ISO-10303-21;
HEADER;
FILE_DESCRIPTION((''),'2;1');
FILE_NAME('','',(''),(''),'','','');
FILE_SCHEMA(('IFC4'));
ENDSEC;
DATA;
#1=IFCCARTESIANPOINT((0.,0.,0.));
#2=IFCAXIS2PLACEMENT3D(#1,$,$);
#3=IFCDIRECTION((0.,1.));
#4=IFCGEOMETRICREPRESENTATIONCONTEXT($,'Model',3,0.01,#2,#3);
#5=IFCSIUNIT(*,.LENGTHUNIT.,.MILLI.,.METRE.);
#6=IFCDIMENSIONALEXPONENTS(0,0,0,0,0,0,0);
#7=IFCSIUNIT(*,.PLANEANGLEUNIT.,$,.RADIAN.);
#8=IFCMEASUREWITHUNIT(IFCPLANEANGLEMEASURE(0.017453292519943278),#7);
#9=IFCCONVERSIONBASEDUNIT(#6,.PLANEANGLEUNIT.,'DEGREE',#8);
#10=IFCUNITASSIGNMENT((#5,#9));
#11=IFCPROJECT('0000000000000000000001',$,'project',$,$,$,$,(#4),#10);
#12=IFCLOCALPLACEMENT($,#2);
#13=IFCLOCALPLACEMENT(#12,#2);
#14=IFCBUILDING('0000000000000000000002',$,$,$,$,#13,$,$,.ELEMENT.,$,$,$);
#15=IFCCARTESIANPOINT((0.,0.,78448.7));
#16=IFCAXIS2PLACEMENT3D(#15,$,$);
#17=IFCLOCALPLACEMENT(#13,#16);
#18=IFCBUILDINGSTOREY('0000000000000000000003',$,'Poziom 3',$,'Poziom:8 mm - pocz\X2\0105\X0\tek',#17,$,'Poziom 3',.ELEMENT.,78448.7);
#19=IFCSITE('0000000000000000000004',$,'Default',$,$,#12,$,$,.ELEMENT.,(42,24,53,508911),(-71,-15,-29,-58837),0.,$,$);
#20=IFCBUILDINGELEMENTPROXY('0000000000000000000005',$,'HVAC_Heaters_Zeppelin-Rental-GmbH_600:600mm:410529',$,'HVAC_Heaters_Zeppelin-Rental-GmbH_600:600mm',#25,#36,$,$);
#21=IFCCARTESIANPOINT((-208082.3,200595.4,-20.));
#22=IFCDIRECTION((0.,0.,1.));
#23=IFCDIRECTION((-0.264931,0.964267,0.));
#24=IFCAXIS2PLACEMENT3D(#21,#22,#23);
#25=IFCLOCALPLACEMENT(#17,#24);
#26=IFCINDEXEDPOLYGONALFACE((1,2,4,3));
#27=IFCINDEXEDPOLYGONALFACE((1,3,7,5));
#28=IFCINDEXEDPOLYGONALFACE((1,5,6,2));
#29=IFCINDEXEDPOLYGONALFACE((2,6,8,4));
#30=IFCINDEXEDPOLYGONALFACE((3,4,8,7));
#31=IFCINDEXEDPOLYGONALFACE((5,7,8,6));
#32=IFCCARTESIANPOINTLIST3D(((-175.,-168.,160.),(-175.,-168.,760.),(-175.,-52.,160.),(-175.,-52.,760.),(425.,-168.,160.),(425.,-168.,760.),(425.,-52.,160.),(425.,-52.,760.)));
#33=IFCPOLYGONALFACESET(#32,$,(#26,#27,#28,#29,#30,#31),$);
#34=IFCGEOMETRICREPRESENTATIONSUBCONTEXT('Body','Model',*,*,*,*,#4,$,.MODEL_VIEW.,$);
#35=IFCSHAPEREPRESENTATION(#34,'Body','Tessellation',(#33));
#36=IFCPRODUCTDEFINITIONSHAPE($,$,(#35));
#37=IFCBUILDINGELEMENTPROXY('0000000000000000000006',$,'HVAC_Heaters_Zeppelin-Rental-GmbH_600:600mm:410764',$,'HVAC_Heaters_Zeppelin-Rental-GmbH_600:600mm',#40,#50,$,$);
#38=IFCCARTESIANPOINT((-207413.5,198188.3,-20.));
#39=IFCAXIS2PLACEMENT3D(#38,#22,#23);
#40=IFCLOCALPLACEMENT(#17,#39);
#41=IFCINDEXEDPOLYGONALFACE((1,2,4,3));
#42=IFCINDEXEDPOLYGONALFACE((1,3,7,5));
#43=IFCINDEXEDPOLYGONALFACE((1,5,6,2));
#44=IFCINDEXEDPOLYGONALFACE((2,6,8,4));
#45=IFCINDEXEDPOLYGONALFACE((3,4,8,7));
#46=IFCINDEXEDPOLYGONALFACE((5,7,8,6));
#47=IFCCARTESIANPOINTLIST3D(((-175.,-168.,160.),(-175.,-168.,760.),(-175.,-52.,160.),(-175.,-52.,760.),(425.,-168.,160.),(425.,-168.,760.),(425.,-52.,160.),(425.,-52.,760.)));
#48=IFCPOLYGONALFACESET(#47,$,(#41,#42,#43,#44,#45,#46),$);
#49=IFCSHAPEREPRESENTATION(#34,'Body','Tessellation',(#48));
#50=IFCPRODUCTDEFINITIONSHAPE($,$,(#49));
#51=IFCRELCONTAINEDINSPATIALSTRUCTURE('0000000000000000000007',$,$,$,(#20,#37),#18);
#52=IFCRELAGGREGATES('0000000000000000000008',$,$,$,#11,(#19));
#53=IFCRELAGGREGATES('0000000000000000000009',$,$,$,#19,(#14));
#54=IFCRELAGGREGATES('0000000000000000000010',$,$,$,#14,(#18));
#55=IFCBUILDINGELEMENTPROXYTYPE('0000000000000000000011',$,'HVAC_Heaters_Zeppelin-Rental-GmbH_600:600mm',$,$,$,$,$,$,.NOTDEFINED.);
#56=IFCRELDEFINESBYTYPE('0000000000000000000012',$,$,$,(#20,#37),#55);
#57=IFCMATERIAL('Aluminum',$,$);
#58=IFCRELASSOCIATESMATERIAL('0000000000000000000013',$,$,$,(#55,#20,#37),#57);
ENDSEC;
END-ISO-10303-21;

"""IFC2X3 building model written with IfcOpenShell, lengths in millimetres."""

from ifc_helpers import new_model, entity, si_unit, converted_unit, direction, frame, frame_2d, origin, place, context, subcontext, project, spatial, rectangle, extrude, source, transform, mapped, material, type_object, type_shapes, element, save


model = new_model("IFC2X3")

# Units and contexts
model_context = context("Model", 3, precision=0.01, world=origin(), true_north=direction((0.0, 1.0)))
body_context = subcontext(model_context, "Body", "Model", "MODEL_VIEW")
ifc_project = project(units=[si_unit("LENGTHUNIT", "METRE", prefix="MILLI"), converted_unit("PLANEANGLEUNIT", "DEGREE", entity("IfcPlaneAngleMeasure", 0.017453292519943278), si_unit("PLANEANGLEUNIT", "RADIAN"), dimensions=[0, 0, 0, 0, 0, 0, 0])], contexts=[model_context])

# Site, building, storey
site_placement = place(None, origin())
site = spatial("IfcSite", under=ifc_project, at=site_placement, Name="Default", CompositionType="ELEMENT", RefLatitude=(42, 24, 53, 508911), RefLongitude=(-71, -15, -29, -58837), RefElevation=0.0)
building_placement = place(site_placement, origin())
building = spatial("IfcBuilding", under=site, at=building_placement, CompositionType="ELEMENT")
storey_placement = place(building_placement, frame((0.0, 0.0, 78448.7)))
storey = spatial("IfcBuildingStorey", under=building, at=storey_placement, Name="Poziom 3", ObjectType="Poziom:8 mm - początek", LongName="Poziom 3", CompositionType="ELEMENT", Elevation=78448.7)

# Shared definitions
ifc_material_1 = material(Name="Aluminum")

# Building element proxies
building_element_proxy_type = type_object("IfcBuildingElementProxyType", Name="HVAC_Heaters_Zeppelin-Rental-GmbH_600:600mm", PredefinedType="NOTDEFINED", material=ifc_material_1)
shared_shape_1 = source(origin(), body_context, "Body", "SweptSolid", [
    extrude(rectangle(XDim=116.0, YDim=600.0, at=frame_2d((0.0, 0.0), x_axis=(1.0, 0.0))), frame((125.0, -110.0, 160.0), z_axis=(0.0, 0.0, 1.0), x_axis=(0.0, 1.0, 0.0)), (0.0, 0.0, 1.0), 600.0),
])
type_shapes(building_element_proxy_type, [shared_shape_1])
for number, where, z_axis, x_axis, name in (
    (1, (-208082.3, 200595.4, -20.0), (0.0, 0.0, 1.0), (-0.264931, 0.964267, 0.0), "HVAC_Heaters_Zeppelin-Rental-GmbH_600:600mm:410529"),
    (2, (-207413.5, 198188.3, -20.0), (0.0, 0.0, 1.0), (-0.264931, 0.964267, 0.0), "HVAC_Heaters_Zeppelin-Rental-GmbH_600:600mm:410764"),
):
    element("IfcBuildingElementProxy", number, at=place(storey_placement, frame(where, z_axis=z_axis, x_axis=x_axis)), inside=storey, type_object=building_element_proxy_type, material=ifc_material_1, Name=name, ObjectType="HVAC_Heaters_Zeppelin-Rental-GmbH_600:600mm", context=body_context, shape_type="MappedRepresentation", body=[
        mapped(shared_shape_1, transform((0.0, 0.0, 0.0), scale=1.0)),
    ])

save(model, "model.ifc")
